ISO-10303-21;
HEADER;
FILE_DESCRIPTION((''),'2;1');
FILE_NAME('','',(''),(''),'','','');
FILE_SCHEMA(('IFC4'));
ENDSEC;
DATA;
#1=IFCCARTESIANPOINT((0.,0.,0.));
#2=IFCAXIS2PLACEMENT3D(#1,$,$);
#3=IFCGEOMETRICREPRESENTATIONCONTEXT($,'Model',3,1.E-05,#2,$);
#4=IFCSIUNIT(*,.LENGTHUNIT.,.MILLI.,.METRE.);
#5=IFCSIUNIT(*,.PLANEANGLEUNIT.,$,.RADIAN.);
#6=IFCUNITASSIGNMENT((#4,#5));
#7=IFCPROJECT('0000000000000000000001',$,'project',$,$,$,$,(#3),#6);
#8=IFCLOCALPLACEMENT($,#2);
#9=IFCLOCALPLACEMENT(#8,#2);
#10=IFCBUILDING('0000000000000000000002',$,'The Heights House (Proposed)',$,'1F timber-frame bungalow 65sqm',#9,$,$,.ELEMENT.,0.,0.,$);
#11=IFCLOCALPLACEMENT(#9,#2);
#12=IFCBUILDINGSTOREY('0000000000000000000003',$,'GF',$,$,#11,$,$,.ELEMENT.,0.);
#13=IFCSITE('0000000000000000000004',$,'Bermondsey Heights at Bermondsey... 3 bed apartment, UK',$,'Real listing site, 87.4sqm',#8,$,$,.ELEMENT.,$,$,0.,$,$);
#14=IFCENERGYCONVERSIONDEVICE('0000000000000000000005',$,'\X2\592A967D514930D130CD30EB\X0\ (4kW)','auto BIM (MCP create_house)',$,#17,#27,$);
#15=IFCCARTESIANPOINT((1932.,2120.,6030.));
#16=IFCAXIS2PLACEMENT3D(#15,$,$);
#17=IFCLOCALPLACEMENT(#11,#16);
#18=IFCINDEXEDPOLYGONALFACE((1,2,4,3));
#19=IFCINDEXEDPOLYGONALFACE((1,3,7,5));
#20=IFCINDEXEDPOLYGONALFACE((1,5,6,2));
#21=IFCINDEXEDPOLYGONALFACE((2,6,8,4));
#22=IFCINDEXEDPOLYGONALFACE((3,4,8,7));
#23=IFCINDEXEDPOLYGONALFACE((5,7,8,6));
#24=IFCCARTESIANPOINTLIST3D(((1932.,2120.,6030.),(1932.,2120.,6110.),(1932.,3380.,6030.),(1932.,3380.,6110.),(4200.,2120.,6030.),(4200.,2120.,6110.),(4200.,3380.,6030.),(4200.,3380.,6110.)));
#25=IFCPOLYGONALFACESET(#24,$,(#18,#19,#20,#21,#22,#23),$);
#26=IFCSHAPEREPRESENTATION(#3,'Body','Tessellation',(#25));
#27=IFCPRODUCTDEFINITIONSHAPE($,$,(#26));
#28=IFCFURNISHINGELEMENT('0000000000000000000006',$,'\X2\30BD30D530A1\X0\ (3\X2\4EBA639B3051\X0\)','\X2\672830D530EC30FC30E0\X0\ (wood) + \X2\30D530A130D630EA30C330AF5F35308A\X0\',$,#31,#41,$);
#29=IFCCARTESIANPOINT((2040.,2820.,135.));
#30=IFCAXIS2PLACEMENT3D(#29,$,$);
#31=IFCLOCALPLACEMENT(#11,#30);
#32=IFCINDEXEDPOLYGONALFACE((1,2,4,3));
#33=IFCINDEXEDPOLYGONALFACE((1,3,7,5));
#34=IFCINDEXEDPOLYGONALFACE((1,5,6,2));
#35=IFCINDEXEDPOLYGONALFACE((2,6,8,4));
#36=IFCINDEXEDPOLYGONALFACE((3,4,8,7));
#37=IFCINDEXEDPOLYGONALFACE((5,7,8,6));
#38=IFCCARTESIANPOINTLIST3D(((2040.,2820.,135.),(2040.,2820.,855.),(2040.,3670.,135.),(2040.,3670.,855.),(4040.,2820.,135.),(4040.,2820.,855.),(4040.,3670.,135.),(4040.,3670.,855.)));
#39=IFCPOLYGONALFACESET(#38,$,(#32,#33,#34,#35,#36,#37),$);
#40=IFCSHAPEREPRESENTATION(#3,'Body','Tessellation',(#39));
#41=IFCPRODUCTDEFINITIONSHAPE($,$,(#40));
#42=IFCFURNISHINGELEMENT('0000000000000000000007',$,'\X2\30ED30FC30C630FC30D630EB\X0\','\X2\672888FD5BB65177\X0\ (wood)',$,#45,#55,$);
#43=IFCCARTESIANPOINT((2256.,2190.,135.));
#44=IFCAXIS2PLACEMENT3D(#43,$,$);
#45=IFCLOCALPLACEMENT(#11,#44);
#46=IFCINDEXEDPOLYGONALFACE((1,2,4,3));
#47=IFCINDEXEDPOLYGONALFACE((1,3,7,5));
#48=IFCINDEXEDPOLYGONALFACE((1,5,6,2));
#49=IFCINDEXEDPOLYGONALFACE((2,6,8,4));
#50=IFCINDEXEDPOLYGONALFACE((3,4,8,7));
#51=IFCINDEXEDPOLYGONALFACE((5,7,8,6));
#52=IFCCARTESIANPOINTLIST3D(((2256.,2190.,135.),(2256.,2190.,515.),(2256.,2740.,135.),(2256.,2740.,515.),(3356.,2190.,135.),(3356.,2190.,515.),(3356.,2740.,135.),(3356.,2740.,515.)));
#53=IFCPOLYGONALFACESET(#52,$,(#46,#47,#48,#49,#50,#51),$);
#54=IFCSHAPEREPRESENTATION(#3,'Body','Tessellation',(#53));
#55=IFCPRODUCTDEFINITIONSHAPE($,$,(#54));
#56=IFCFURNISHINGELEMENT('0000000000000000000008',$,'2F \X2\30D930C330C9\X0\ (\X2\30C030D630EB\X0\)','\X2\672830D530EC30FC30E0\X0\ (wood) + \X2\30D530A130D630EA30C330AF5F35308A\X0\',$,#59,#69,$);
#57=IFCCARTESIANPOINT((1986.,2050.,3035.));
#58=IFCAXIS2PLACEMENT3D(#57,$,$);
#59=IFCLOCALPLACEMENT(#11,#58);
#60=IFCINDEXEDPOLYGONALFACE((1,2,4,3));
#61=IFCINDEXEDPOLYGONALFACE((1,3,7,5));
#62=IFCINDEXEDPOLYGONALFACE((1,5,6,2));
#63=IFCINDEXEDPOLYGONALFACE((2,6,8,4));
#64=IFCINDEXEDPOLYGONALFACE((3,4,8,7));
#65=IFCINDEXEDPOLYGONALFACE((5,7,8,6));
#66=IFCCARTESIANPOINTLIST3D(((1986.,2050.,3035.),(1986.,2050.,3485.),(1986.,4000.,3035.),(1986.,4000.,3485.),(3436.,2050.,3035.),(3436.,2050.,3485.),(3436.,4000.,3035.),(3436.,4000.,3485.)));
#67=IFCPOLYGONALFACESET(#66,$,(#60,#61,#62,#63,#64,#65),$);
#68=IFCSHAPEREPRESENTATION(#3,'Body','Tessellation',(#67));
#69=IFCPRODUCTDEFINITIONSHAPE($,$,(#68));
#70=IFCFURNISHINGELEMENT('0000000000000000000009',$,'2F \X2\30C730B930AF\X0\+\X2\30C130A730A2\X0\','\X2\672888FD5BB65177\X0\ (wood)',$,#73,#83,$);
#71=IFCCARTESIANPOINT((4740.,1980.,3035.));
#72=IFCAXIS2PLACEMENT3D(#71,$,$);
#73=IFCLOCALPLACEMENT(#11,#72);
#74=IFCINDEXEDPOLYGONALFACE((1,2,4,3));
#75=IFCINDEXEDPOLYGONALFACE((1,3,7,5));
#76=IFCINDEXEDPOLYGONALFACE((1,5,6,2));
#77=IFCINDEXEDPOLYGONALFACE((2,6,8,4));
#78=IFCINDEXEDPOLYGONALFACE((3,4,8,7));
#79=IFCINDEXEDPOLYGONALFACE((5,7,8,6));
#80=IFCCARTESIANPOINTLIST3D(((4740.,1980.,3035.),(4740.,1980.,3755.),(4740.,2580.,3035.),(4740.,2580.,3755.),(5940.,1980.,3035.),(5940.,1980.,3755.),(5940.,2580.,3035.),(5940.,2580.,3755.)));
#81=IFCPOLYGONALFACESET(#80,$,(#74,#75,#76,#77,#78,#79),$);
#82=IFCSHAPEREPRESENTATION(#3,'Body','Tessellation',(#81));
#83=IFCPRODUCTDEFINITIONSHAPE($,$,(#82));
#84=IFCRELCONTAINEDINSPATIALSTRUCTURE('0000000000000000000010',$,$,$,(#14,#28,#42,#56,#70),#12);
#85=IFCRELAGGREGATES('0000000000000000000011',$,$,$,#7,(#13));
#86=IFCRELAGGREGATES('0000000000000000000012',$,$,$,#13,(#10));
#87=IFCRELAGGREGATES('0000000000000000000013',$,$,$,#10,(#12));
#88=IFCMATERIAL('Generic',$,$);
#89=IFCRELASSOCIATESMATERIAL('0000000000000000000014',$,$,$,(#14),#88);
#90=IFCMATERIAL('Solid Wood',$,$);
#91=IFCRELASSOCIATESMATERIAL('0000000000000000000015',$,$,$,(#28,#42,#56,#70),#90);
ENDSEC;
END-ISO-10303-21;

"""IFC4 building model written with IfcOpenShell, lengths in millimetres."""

from ifc_helpers import new_model, si_unit, frame, frame_2d, origin, place, context, project, spatial, rectangle, extrude, material, element, save


model = new_model("IFC4")

# Units and contexts
model_context = context("Model", 3, precision=1e-05, world=origin())
ifc_project = project(units=[si_unit("LENGTHUNIT", "METRE", prefix="MILLI"), si_unit("PLANEANGLEUNIT", "RADIAN")], contexts=[model_context])

# Site, building, storey
site_placement = place(None, origin())
site = spatial("IfcSite", under=ifc_project, at=site_placement, Name="Bermondsey Heights at Bermondsey... 3 bed apartment, UK", ObjectType="Real listing site, 87.4sqm", CompositionType="ELEMENT", RefElevation=0.0)
building_placement = place(site_placement, origin())
building = spatial("IfcBuilding", under=site, at=building_placement, Name="The Heights House (Proposed)", ObjectType="1F timber-frame bungalow 65sqm", CompositionType="ELEMENT", ElevationOfRefHeight=0.0, ElevationOfTerrain=0.0)
storey_placement = place(building_placement, origin())
storey = spatial("IfcBuildingStorey", under=building, at=storey_placement, Name="GF", CompositionType="ELEMENT", Elevation=0.0)

# Shared definitions
ifc_material_1 = material(Name="Solid Wood")

# Shared definitions
ifc_material_2 = material(Name="Generic")

# Energy conversion device
energy_conversion_device_placement = place(storey_placement, frame((1932.0, 2120.0, 6030.0)))
element("IfcEnergyConversionDevice", 1, at=energy_conversion_device_placement, inside=storey, material=ifc_material_2, Name="太陽光パネル (4kW)", Description="auto BIM (MCP create_house)", context=model_context, shape_type="SweptSolid", body=[
    extrude(rectangle(XDim=2268.0, YDim=1260.0, at=frame_2d((1134.0, 630.0))), frame((1932.0, 2120.0, 6030.0)), (0.0, 0.0, 1.0), 80.0),
])

# Furnishing elements
furnishing_1_placement = place(storey_placement, frame((2040.0, 2820.0, 135.0)))
element("IfcFurnishingElement", 2, at=furnishing_1_placement, inside=storey, material=ifc_material_1, Name="ソファ (3人掛け)", Description="木フレーム (wood) + ファブリック張り", context=model_context, shape_type="SweptSolid", body=[
    extrude(rectangle(XDim=2000.0, YDim=850.0, at=frame_2d((1000.0, 425.0))), frame((2040.0, 2820.0, 135.0)), (0.0, 0.0, 1.0), 720.0),
])
furnishing_2_placement = place(storey_placement, frame((2256.0, 2190.0, 135.0)))
element("IfcFurnishingElement", 3, at=furnishing_2_placement, inside=storey, material=ifc_material_1, Name="ローテーブル", Description="木製家具 (wood)", context=model_context, shape_type="SweptSolid", body=[
    extrude(rectangle(XDim=1100.0, YDim=550.0, at=frame_2d((550.0, 275.0))), frame((2256.0, 2190.0, 135.0)), (0.0, 0.0, 1.0), 380.0),
])
furnishing_3_placement = place(storey_placement, frame((1986.0, 2050.0, 3035.0)))
element("IfcFurnishingElement", 4, at=furnishing_3_placement, inside=storey, material=ifc_material_1, Name="2F ベッド (ダブル)", Description="木フレーム (wood) + ファブリック張り", context=model_context, shape_type="SweptSolid", body=[
    extrude(rectangle(XDim=1450.0, YDim=1950.0, at=frame_2d((725.0, 975.0))), frame((1986.0, 2050.0, 3035.0)), (0.0, 0.0, 1.0), 450.0),
])
furnishing_4_placement = place(storey_placement, frame((4740.0, 1980.0, 3035.0)))
element("IfcFurnishingElement", 5, at=furnishing_4_placement, inside=storey, material=ifc_material_1, Name="2F デスク+チェア", Description="木製家具 (wood)", context=model_context, shape_type="SweptSolid", body=[
    extrude(rectangle(XDim=1200.0, YDim=600.0, at=frame_2d((600.0, 300.0))), frame((4740.0, 1980.0, 3035.0)), (0.0, 0.0, 1.0), 720.0),
])

save(model, "model.ifc")
